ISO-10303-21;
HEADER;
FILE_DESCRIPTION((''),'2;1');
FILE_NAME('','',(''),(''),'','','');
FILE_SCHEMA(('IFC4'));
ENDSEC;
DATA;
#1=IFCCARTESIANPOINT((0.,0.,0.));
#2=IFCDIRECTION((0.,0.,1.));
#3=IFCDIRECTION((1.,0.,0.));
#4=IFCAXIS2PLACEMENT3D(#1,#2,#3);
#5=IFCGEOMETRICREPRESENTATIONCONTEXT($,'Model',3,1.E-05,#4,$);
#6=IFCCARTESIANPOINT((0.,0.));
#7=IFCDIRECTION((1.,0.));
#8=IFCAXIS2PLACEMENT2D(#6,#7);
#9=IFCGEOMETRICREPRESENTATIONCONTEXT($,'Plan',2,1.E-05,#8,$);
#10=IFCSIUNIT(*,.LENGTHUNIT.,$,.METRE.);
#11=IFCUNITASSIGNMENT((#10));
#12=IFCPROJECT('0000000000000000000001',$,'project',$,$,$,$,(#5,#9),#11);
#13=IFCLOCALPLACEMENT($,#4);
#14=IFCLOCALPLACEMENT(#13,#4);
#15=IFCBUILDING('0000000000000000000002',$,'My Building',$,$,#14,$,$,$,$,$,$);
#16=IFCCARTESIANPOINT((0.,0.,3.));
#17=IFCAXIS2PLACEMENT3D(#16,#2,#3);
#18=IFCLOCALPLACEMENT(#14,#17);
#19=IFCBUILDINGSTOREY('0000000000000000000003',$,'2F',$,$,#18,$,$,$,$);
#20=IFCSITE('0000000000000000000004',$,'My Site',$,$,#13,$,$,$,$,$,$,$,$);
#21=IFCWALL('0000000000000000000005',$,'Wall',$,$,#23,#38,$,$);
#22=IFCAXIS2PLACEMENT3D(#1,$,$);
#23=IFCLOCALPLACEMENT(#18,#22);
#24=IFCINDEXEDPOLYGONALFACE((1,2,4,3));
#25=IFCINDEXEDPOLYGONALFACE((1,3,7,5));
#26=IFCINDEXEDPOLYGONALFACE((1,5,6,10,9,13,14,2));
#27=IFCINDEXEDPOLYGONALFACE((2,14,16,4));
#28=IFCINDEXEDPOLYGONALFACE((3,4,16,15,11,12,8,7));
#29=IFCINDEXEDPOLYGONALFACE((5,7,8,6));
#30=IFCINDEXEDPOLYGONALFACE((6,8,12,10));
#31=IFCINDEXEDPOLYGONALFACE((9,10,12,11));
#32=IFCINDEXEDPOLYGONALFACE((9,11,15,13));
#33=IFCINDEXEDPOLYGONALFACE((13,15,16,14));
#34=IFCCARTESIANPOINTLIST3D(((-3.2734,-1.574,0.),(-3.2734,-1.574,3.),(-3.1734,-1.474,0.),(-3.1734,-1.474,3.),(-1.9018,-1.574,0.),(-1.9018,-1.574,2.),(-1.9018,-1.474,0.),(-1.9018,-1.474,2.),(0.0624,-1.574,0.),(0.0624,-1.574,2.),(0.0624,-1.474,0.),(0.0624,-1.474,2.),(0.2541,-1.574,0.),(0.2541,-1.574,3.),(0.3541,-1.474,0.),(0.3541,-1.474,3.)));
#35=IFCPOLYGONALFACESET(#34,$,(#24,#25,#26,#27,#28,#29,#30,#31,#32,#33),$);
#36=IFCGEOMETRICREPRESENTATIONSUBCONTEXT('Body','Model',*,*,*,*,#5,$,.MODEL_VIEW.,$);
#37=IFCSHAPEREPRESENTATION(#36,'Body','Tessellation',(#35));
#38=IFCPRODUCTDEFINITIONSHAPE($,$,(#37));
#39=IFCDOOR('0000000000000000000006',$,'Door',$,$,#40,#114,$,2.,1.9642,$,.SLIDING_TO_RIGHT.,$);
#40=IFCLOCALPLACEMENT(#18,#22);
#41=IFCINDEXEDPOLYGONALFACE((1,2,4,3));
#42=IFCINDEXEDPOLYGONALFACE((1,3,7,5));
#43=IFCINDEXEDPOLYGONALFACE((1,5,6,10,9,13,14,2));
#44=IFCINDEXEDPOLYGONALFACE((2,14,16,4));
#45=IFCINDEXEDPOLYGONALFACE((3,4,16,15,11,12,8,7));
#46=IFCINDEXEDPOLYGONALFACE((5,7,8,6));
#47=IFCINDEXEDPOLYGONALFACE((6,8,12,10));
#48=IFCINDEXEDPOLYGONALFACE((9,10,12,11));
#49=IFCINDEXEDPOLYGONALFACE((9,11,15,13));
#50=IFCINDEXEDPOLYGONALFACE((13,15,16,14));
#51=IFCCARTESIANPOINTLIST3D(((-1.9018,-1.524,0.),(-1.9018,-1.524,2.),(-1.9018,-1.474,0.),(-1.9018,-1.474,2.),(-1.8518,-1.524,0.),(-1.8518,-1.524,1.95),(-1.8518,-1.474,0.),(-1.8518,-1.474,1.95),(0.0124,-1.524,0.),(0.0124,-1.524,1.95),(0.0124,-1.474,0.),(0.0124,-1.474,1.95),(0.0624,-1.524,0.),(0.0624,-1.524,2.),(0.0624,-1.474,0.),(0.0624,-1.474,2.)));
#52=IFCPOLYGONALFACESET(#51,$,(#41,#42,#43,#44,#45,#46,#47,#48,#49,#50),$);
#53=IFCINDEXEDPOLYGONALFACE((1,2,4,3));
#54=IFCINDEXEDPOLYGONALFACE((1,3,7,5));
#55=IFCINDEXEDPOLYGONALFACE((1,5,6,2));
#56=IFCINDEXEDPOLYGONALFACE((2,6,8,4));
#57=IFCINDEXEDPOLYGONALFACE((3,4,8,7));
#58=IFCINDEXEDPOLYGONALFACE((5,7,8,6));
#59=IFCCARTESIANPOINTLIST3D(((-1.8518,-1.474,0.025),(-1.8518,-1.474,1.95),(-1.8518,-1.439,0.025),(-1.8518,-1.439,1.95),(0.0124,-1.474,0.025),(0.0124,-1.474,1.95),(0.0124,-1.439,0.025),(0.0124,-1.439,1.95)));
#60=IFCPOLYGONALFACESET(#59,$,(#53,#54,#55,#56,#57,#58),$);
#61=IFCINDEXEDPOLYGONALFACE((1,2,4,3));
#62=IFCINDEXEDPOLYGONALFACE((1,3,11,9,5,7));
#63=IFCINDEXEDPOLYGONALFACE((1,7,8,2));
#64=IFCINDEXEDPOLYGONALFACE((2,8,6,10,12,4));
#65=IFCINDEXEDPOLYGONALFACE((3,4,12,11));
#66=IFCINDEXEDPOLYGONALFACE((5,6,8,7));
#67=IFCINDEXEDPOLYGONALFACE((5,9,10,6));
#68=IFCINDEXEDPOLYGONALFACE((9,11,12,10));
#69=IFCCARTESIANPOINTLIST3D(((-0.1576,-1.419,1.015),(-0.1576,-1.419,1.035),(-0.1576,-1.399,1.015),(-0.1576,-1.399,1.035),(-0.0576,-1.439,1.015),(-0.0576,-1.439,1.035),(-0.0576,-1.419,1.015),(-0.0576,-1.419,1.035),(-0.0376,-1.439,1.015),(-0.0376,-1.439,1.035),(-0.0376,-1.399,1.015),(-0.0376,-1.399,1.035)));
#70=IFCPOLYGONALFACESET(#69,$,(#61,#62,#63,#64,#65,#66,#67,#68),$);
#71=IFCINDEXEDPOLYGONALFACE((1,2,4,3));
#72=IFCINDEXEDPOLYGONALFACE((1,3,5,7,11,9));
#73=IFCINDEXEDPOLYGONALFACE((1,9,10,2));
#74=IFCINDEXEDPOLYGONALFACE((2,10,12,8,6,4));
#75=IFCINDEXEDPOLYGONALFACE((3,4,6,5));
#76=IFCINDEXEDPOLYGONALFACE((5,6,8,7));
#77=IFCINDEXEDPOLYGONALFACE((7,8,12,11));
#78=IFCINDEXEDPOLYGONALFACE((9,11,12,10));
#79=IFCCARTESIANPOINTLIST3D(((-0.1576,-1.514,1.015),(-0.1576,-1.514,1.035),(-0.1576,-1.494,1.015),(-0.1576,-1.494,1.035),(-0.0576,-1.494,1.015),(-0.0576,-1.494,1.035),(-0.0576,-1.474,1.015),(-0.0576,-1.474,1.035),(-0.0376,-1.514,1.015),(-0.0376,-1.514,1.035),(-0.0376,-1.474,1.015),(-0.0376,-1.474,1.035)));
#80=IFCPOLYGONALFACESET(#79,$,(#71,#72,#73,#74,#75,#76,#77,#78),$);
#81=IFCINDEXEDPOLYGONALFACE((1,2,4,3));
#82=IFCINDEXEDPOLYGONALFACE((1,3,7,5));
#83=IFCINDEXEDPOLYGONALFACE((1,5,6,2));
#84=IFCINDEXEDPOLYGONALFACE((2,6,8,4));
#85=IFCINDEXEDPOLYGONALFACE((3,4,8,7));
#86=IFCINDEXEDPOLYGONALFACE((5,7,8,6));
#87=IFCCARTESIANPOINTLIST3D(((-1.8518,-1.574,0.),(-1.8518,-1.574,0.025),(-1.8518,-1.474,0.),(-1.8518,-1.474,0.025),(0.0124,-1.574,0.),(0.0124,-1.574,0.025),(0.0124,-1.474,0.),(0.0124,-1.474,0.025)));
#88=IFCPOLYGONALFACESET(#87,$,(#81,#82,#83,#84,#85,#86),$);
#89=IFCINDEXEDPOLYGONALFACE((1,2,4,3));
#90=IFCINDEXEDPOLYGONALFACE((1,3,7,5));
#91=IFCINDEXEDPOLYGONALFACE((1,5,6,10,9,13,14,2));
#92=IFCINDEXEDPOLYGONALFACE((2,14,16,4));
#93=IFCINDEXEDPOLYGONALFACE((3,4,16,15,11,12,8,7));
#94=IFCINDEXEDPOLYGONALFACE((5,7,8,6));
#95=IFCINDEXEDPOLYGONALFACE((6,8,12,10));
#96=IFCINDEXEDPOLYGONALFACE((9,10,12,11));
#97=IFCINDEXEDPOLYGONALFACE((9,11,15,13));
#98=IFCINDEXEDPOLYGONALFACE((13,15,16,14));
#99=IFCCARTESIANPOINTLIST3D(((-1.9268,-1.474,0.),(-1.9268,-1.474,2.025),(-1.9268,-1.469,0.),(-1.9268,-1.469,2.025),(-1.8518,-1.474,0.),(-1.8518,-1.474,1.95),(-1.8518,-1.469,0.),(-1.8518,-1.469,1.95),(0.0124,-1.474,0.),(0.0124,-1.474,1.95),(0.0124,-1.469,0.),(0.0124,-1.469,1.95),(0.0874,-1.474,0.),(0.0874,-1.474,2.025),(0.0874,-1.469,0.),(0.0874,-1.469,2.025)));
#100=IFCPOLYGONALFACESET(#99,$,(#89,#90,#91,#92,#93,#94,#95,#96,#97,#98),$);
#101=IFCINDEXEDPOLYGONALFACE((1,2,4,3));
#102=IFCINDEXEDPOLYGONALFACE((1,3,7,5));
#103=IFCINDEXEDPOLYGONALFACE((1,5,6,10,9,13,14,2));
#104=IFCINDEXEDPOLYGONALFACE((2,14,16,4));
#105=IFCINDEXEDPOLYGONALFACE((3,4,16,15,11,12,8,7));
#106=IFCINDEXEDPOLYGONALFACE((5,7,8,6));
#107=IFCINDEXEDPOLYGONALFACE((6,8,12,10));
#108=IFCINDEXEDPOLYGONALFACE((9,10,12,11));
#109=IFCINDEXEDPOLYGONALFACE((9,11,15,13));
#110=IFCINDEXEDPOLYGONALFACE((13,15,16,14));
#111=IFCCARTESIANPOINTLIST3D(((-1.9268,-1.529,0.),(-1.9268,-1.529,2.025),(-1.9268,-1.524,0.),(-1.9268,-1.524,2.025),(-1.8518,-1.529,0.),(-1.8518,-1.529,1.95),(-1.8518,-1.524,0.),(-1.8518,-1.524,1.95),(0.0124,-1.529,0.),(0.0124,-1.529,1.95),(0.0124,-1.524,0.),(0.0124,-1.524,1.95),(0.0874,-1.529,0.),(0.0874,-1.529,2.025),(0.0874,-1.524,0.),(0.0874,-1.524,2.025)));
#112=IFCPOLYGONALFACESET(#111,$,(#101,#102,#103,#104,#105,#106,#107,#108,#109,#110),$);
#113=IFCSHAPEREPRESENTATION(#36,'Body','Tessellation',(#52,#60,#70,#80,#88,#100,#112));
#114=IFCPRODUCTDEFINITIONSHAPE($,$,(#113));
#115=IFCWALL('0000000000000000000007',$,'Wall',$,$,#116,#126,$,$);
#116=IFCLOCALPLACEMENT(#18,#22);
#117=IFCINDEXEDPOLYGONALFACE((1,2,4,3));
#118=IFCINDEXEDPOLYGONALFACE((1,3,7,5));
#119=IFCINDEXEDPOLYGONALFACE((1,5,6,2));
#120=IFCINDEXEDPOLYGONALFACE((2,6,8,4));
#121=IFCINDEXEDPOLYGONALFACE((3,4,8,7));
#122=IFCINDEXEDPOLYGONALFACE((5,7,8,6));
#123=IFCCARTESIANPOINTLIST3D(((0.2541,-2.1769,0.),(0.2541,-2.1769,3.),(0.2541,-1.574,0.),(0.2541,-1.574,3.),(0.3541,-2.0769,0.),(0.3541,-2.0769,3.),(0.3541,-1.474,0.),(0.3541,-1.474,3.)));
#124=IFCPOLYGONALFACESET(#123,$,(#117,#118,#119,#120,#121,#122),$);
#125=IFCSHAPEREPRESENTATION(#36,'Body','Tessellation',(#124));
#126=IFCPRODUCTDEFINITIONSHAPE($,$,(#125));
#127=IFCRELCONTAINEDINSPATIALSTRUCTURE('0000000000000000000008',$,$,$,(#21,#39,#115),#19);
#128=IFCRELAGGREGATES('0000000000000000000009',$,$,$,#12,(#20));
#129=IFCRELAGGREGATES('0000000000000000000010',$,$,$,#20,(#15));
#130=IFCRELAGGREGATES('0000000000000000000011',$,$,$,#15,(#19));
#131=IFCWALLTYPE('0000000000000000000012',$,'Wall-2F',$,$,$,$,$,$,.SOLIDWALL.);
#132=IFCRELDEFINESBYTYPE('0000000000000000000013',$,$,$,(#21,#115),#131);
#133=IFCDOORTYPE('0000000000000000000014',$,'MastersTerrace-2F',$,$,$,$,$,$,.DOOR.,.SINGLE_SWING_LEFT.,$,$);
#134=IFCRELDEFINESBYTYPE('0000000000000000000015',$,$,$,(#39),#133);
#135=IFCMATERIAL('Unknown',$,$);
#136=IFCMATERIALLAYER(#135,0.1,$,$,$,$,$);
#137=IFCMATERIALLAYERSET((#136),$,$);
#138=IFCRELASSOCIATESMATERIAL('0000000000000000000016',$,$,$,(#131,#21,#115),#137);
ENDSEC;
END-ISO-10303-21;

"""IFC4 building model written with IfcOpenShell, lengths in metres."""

from ifc_helpers import new_model, entity, si_unit, frame, origin_with_axes, origin_2d_with_axis, place, context, subcontext, project, spatial, line, indexed_curve, outline, extrude, shape, source, transform, mapped, material, layer, layer_set, layer_usage, type_object, type_shapes, element, fill, save


model = new_model("IFC4")

# Units and contexts
model_context = context("Model", 3, precision=1e-05, world=origin_with_axes())
plan_context = context("Plan", 2, precision=1e-05, world=origin_2d_with_axis())
body_context_1 = subcontext(model_context, "Body", "Model", "MODEL_VIEW")
body_context_2 = subcontext(plan_context, "Body", "Plan", "PLAN_VIEW")
ifc_project = project(units=[si_unit("LENGTHUNIT", "METRE")], contexts=[model_context, plan_context])

# Site, building, storey
site_placement = place(None, origin_with_axes())
site = spatial("IfcSite", under=ifc_project, at=site_placement, Name="My Site")
building_placement = place(site_placement, origin_with_axes())
building = spatial("IfcBuilding", under=site, at=building_placement, Name="My Building")
storey_placement = place(building_placement, frame((0.0, 0.0, 3.0), z_axis=(0.0, 0.0, 1.0), x_axis=(1.0, 0.0, 0.0)))
storey = spatial("IfcBuildingStorey", under=building, at=storey_placement, Name="2F")

# Shared definitions
ifc_material = material(Name="Unknown")

# Shared definitions
ifc_layer_1 = layer(ifc_material, 0.1)
ifc_layer_set_1 = layer_set([ifc_layer_1])
wall_type_1 = type_object("IfcWallType", Name="Wall-2F", PredefinedType="SOLIDWALL", material=ifc_layer_set_1)

# Wall, opening, door
ifc_layer_usage_1 = layer_usage(ifc_layer_set_1, "AXIS2", "POSITIVE", 0.0)
wall_1_placement = place(storey_placement, frame((-3.2734, -1.574, 0.0), z_axis=(0.0, 0.0, 1.0), x_axis=(1.0, 0.0, 0.0)))
wall_1 = element("IfcWall", 1, at=wall_1_placement, inside=storey, type_object=wall_type_1, material=ifc_layer_usage_1, Name="Wall", context=body_context_1, shape_type="SweptSolid", body=[
    extrude(outline(indexed_curve([(0.0, 0.0), (0.1, 0.1), (3.6275, 0.1), (3.5275, 0.0)], segments=[line(1, 2, 3, 4, 1)])), origin_with_axes(), (0.0, 0.0, 1.0), 3.0),
])
shared_shape_1 = source(origin_with_axes(), body_context_1, "Body", "SweptSolid", [
    extrude(outline(indexed_curve([(0.0, 0.0), (1.9642, 0.0), (1.9642, 2.0), (0.0, 2.0)], segments=[line(1, 2, 3, 4, 1)])), frame((0.0, -0.6, 0.0), z_axis=(0.0, -1.0, 0.0), x_axis=(1.0, 0.0, 0.0)), (0.0, 0.0, -1.0), 1.2),
])
opening_1_placement = place(wall_1_placement, frame((3.3358, 0.1, 0.0), z_axis=(0.0, 0.0, 1.0), x_axis=(-1.0, 0.0, 0.0)))
opening_1 = element("IfcOpeningElement", 2, at=opening_1_placement, cuts=wall_1, PredefinedType="OPENING", context=body_context_1, shape_type="MappedRepresentation", body=[
    mapped(shared_shape_1, transform((0.0, 0.0, 0.0), x_axis=(1.0, 0.0, 0.0), y_axis=(0.0, 1.0, 0.0), z_axis=(0.0, 0.0, 1.0), scale=1.0)),
])
door_type_1 = type_object("IfcDoorType", Name="MastersTerrace-2F", OperationType="SINGLE_SWING_LEFT", PredefinedType="DOOR")
shared_shape_2 = source(origin_with_axes(), body_context_1, "Body", "SweptSolid", [
    extrude(outline(indexed_curve([(0.0, 0.0), (0.0, 2.0), (1.9642, 2.0), (1.9642, 0.0), (1.9142, 0.0), (1.9142, 1.95), (0.05, 1.95), (0.05, 0.0)], segments=[line(1, 2, 3, 4, 5, 6, 7, 8, 1)])), frame((0.0, 0.0, 0.0), z_axis=(0.0, -1.0, 0.0), x_axis=(1.0, 0.0, 0.0)), (0.0, 0.0, -1.0), 0.05),
    extrude(outline(indexed_curve([(0.0, 0.0), (1.8642, 0.0), (1.8642, 0.035), (0.0, 0.035)], segments=[line(1, 2, 3, 4, 1)])), frame((0.05, -0.035, 0.025), z_axis=(0.0, 0.0, 1.0), x_axis=(1.0, 0.0, 0.0)), (0.0, 0.0, 1.0), 1.925),
    extrude(outline(indexed_curve([(0.0, 0.0), (0.0, -0.04), (0.12, -0.04), (0.12, -0.02), (0.02, -0.02), (0.02, 0.0)], segments=[line(1, 2, 3, 4, 5, 6, 1)])), frame((0.1, -0.035, 1.015), z_axis=(0.0, 0.0, 1.0), x_axis=(1.0, 0.0, 0.0)), (0.0, 0.0, 1.0), 0.02),
    extrude(outline(indexed_curve([(0.0, 0.0), (0.0, 0.04), (0.12, 0.04), (0.12, 0.02), (0.02, 0.02), (0.02, 0.0)], segments=[line(1, 2, 3, 4, 5, 6, 1)])), frame((0.1, 0.0, 1.015), z_axis=(0.0, 0.0, 1.0), x_axis=(1.0, 0.0, 0.0)), (0.0, 0.0, 1.0), 0.02),
    extrude(outline(indexed_curve([(0.0, 0.0), (1.8642, 0.0), (1.8642, 0.1), (0.0, 0.1)], segments=[line(1, 2, 3, 4, 1)])), frame((0.05, 0.0, 0.0), z_axis=(0.0, 0.0, 1.0), x_axis=(1.0, 0.0, 0.0)), (0.0, 0.0, 1.0), 0.025),
    extrude(outline(indexed_curve([(0.0, 0.0), (0.0, 2.025), (2.0142, 2.025), (2.0142, 0.0), (1.9392, 0.0), (1.9392, 1.95), (0.075, 1.95), (0.075, 0.0)], segments=[line(1, 2, 3, 4, 5, 6, 7, 8, 1)])), frame((-0.025, -0.005, 0.0), z_axis=(0.0, -1.0, 0.0), x_axis=(1.0, 0.0, 0.0)), (0.0, 0.0, -1.0), 0.005),
    extrude(outline(indexed_curve([(0.0, 0.0), (0.0, 2.025), (2.0142, 2.025), (2.0142, 0.0), (1.9392, 0.0), (1.9392, 1.95), (0.075, 1.95), (0.075, 0.0)], segments=[line(1, 2, 3, 4, 5, 6, 7, 8, 1)])), frame((-0.025, 0.05, 0.0), z_axis=(0.0, -1.0, 0.0), x_axis=(1.0, 0.0, 0.0)), (0.0, 0.0, -1.0), 0.005),
])
shared_shape_3 = source(origin_with_axes(), body_context_2, "Body", "Curve2D", [
    entity("IfcIndexedPolyCurve", entity("IfcCartesianPointList2D", [[0.0, 0.0], [0.05, 0.0], [0.05, 0.05], [0.0, 0.05]]), [entity("IfcLineIndex", [1, 2, 3, 4, 1])]),
    entity("IfcIndexedPolyCurve", entity("IfcCartesianPointList2D", [[1.9642, 0.0], [1.9142, 0.0], [1.9142, 0.05], [1.9642, 0.05]]), [entity("IfcLineIndex", [1, 2, 3, 4, 1])]),
    entity("IfcIndexedPolyCurve", entity("IfcCartesianPointList2D", [[2.8463, -0.035], [0.9821, -0.035], [0.9821, 0.0], [2.8463, 0.0]]), [entity("IfcLineIndex", [1, 2, 3, 4, 1])]),
])
type_shapes(door_type_1, [shared_shape_2, shared_shape_3])
door_1_placement = place(opening_1_placement, origin_with_axes())
door_1 = element("IfcDoor", 3, at=door_1_placement, inside=storey, type_object=door_type_1, Name="Door", OperationType="SLIDING_TO_RIGHT", OverallHeight=2.0, OverallWidth=1.9642, shapes=[
    shape(body_context_1, "Body", "MappedRepresentation", [mapped(shared_shape_2, transform((0.0, 0.0, 0.0), x_axis=(1.0, 0.0, 0.0), y_axis=(0.0, 1.0, 0.0), z_axis=(0.0, 0.0, 1.0), scale=1.0))]),
    shape(body_context_2, "Body", "MappedRepresentation", [mapped(shared_shape_3, transform((0.0, 0.0, 0.0), x_axis=(1.0, 0.0, 0.0), y_axis=(0.0, 1.0, 0.0), z_axis=(0.0, 0.0, 1.0), scale=1.0))]),
])
fill(opening_1, door_1)

# Wall
ifc_layer_usage_2 = layer_usage(ifc_layer_set_1, "AXIS2", "POSITIVE", 0.0)
wall_2_placement = place(storey_placement, frame((0.2541, -1.574, 0.0), z_axis=(0.0, 0.0, 1.0), x_axis=(0.0, -1.0, 0.0)))
element("IfcWall", 4, at=wall_2_placement, inside=storey, type_object=wall_type_1, material=ifc_layer_usage_2, Name="Wall", context=body_context_1, shape_type="SweptSolid", body=[
    extrude(outline(indexed_curve([(0.0, 0.0), (-0.1, 0.1), (0.5029, 0.1), (0.6029, 0.0)], segments=[line(1, 2, 3, 4, 1)])), origin_with_axes(), (0.0, 0.0, 1.0), 3.0),
])

save(model, "model.ifc")
